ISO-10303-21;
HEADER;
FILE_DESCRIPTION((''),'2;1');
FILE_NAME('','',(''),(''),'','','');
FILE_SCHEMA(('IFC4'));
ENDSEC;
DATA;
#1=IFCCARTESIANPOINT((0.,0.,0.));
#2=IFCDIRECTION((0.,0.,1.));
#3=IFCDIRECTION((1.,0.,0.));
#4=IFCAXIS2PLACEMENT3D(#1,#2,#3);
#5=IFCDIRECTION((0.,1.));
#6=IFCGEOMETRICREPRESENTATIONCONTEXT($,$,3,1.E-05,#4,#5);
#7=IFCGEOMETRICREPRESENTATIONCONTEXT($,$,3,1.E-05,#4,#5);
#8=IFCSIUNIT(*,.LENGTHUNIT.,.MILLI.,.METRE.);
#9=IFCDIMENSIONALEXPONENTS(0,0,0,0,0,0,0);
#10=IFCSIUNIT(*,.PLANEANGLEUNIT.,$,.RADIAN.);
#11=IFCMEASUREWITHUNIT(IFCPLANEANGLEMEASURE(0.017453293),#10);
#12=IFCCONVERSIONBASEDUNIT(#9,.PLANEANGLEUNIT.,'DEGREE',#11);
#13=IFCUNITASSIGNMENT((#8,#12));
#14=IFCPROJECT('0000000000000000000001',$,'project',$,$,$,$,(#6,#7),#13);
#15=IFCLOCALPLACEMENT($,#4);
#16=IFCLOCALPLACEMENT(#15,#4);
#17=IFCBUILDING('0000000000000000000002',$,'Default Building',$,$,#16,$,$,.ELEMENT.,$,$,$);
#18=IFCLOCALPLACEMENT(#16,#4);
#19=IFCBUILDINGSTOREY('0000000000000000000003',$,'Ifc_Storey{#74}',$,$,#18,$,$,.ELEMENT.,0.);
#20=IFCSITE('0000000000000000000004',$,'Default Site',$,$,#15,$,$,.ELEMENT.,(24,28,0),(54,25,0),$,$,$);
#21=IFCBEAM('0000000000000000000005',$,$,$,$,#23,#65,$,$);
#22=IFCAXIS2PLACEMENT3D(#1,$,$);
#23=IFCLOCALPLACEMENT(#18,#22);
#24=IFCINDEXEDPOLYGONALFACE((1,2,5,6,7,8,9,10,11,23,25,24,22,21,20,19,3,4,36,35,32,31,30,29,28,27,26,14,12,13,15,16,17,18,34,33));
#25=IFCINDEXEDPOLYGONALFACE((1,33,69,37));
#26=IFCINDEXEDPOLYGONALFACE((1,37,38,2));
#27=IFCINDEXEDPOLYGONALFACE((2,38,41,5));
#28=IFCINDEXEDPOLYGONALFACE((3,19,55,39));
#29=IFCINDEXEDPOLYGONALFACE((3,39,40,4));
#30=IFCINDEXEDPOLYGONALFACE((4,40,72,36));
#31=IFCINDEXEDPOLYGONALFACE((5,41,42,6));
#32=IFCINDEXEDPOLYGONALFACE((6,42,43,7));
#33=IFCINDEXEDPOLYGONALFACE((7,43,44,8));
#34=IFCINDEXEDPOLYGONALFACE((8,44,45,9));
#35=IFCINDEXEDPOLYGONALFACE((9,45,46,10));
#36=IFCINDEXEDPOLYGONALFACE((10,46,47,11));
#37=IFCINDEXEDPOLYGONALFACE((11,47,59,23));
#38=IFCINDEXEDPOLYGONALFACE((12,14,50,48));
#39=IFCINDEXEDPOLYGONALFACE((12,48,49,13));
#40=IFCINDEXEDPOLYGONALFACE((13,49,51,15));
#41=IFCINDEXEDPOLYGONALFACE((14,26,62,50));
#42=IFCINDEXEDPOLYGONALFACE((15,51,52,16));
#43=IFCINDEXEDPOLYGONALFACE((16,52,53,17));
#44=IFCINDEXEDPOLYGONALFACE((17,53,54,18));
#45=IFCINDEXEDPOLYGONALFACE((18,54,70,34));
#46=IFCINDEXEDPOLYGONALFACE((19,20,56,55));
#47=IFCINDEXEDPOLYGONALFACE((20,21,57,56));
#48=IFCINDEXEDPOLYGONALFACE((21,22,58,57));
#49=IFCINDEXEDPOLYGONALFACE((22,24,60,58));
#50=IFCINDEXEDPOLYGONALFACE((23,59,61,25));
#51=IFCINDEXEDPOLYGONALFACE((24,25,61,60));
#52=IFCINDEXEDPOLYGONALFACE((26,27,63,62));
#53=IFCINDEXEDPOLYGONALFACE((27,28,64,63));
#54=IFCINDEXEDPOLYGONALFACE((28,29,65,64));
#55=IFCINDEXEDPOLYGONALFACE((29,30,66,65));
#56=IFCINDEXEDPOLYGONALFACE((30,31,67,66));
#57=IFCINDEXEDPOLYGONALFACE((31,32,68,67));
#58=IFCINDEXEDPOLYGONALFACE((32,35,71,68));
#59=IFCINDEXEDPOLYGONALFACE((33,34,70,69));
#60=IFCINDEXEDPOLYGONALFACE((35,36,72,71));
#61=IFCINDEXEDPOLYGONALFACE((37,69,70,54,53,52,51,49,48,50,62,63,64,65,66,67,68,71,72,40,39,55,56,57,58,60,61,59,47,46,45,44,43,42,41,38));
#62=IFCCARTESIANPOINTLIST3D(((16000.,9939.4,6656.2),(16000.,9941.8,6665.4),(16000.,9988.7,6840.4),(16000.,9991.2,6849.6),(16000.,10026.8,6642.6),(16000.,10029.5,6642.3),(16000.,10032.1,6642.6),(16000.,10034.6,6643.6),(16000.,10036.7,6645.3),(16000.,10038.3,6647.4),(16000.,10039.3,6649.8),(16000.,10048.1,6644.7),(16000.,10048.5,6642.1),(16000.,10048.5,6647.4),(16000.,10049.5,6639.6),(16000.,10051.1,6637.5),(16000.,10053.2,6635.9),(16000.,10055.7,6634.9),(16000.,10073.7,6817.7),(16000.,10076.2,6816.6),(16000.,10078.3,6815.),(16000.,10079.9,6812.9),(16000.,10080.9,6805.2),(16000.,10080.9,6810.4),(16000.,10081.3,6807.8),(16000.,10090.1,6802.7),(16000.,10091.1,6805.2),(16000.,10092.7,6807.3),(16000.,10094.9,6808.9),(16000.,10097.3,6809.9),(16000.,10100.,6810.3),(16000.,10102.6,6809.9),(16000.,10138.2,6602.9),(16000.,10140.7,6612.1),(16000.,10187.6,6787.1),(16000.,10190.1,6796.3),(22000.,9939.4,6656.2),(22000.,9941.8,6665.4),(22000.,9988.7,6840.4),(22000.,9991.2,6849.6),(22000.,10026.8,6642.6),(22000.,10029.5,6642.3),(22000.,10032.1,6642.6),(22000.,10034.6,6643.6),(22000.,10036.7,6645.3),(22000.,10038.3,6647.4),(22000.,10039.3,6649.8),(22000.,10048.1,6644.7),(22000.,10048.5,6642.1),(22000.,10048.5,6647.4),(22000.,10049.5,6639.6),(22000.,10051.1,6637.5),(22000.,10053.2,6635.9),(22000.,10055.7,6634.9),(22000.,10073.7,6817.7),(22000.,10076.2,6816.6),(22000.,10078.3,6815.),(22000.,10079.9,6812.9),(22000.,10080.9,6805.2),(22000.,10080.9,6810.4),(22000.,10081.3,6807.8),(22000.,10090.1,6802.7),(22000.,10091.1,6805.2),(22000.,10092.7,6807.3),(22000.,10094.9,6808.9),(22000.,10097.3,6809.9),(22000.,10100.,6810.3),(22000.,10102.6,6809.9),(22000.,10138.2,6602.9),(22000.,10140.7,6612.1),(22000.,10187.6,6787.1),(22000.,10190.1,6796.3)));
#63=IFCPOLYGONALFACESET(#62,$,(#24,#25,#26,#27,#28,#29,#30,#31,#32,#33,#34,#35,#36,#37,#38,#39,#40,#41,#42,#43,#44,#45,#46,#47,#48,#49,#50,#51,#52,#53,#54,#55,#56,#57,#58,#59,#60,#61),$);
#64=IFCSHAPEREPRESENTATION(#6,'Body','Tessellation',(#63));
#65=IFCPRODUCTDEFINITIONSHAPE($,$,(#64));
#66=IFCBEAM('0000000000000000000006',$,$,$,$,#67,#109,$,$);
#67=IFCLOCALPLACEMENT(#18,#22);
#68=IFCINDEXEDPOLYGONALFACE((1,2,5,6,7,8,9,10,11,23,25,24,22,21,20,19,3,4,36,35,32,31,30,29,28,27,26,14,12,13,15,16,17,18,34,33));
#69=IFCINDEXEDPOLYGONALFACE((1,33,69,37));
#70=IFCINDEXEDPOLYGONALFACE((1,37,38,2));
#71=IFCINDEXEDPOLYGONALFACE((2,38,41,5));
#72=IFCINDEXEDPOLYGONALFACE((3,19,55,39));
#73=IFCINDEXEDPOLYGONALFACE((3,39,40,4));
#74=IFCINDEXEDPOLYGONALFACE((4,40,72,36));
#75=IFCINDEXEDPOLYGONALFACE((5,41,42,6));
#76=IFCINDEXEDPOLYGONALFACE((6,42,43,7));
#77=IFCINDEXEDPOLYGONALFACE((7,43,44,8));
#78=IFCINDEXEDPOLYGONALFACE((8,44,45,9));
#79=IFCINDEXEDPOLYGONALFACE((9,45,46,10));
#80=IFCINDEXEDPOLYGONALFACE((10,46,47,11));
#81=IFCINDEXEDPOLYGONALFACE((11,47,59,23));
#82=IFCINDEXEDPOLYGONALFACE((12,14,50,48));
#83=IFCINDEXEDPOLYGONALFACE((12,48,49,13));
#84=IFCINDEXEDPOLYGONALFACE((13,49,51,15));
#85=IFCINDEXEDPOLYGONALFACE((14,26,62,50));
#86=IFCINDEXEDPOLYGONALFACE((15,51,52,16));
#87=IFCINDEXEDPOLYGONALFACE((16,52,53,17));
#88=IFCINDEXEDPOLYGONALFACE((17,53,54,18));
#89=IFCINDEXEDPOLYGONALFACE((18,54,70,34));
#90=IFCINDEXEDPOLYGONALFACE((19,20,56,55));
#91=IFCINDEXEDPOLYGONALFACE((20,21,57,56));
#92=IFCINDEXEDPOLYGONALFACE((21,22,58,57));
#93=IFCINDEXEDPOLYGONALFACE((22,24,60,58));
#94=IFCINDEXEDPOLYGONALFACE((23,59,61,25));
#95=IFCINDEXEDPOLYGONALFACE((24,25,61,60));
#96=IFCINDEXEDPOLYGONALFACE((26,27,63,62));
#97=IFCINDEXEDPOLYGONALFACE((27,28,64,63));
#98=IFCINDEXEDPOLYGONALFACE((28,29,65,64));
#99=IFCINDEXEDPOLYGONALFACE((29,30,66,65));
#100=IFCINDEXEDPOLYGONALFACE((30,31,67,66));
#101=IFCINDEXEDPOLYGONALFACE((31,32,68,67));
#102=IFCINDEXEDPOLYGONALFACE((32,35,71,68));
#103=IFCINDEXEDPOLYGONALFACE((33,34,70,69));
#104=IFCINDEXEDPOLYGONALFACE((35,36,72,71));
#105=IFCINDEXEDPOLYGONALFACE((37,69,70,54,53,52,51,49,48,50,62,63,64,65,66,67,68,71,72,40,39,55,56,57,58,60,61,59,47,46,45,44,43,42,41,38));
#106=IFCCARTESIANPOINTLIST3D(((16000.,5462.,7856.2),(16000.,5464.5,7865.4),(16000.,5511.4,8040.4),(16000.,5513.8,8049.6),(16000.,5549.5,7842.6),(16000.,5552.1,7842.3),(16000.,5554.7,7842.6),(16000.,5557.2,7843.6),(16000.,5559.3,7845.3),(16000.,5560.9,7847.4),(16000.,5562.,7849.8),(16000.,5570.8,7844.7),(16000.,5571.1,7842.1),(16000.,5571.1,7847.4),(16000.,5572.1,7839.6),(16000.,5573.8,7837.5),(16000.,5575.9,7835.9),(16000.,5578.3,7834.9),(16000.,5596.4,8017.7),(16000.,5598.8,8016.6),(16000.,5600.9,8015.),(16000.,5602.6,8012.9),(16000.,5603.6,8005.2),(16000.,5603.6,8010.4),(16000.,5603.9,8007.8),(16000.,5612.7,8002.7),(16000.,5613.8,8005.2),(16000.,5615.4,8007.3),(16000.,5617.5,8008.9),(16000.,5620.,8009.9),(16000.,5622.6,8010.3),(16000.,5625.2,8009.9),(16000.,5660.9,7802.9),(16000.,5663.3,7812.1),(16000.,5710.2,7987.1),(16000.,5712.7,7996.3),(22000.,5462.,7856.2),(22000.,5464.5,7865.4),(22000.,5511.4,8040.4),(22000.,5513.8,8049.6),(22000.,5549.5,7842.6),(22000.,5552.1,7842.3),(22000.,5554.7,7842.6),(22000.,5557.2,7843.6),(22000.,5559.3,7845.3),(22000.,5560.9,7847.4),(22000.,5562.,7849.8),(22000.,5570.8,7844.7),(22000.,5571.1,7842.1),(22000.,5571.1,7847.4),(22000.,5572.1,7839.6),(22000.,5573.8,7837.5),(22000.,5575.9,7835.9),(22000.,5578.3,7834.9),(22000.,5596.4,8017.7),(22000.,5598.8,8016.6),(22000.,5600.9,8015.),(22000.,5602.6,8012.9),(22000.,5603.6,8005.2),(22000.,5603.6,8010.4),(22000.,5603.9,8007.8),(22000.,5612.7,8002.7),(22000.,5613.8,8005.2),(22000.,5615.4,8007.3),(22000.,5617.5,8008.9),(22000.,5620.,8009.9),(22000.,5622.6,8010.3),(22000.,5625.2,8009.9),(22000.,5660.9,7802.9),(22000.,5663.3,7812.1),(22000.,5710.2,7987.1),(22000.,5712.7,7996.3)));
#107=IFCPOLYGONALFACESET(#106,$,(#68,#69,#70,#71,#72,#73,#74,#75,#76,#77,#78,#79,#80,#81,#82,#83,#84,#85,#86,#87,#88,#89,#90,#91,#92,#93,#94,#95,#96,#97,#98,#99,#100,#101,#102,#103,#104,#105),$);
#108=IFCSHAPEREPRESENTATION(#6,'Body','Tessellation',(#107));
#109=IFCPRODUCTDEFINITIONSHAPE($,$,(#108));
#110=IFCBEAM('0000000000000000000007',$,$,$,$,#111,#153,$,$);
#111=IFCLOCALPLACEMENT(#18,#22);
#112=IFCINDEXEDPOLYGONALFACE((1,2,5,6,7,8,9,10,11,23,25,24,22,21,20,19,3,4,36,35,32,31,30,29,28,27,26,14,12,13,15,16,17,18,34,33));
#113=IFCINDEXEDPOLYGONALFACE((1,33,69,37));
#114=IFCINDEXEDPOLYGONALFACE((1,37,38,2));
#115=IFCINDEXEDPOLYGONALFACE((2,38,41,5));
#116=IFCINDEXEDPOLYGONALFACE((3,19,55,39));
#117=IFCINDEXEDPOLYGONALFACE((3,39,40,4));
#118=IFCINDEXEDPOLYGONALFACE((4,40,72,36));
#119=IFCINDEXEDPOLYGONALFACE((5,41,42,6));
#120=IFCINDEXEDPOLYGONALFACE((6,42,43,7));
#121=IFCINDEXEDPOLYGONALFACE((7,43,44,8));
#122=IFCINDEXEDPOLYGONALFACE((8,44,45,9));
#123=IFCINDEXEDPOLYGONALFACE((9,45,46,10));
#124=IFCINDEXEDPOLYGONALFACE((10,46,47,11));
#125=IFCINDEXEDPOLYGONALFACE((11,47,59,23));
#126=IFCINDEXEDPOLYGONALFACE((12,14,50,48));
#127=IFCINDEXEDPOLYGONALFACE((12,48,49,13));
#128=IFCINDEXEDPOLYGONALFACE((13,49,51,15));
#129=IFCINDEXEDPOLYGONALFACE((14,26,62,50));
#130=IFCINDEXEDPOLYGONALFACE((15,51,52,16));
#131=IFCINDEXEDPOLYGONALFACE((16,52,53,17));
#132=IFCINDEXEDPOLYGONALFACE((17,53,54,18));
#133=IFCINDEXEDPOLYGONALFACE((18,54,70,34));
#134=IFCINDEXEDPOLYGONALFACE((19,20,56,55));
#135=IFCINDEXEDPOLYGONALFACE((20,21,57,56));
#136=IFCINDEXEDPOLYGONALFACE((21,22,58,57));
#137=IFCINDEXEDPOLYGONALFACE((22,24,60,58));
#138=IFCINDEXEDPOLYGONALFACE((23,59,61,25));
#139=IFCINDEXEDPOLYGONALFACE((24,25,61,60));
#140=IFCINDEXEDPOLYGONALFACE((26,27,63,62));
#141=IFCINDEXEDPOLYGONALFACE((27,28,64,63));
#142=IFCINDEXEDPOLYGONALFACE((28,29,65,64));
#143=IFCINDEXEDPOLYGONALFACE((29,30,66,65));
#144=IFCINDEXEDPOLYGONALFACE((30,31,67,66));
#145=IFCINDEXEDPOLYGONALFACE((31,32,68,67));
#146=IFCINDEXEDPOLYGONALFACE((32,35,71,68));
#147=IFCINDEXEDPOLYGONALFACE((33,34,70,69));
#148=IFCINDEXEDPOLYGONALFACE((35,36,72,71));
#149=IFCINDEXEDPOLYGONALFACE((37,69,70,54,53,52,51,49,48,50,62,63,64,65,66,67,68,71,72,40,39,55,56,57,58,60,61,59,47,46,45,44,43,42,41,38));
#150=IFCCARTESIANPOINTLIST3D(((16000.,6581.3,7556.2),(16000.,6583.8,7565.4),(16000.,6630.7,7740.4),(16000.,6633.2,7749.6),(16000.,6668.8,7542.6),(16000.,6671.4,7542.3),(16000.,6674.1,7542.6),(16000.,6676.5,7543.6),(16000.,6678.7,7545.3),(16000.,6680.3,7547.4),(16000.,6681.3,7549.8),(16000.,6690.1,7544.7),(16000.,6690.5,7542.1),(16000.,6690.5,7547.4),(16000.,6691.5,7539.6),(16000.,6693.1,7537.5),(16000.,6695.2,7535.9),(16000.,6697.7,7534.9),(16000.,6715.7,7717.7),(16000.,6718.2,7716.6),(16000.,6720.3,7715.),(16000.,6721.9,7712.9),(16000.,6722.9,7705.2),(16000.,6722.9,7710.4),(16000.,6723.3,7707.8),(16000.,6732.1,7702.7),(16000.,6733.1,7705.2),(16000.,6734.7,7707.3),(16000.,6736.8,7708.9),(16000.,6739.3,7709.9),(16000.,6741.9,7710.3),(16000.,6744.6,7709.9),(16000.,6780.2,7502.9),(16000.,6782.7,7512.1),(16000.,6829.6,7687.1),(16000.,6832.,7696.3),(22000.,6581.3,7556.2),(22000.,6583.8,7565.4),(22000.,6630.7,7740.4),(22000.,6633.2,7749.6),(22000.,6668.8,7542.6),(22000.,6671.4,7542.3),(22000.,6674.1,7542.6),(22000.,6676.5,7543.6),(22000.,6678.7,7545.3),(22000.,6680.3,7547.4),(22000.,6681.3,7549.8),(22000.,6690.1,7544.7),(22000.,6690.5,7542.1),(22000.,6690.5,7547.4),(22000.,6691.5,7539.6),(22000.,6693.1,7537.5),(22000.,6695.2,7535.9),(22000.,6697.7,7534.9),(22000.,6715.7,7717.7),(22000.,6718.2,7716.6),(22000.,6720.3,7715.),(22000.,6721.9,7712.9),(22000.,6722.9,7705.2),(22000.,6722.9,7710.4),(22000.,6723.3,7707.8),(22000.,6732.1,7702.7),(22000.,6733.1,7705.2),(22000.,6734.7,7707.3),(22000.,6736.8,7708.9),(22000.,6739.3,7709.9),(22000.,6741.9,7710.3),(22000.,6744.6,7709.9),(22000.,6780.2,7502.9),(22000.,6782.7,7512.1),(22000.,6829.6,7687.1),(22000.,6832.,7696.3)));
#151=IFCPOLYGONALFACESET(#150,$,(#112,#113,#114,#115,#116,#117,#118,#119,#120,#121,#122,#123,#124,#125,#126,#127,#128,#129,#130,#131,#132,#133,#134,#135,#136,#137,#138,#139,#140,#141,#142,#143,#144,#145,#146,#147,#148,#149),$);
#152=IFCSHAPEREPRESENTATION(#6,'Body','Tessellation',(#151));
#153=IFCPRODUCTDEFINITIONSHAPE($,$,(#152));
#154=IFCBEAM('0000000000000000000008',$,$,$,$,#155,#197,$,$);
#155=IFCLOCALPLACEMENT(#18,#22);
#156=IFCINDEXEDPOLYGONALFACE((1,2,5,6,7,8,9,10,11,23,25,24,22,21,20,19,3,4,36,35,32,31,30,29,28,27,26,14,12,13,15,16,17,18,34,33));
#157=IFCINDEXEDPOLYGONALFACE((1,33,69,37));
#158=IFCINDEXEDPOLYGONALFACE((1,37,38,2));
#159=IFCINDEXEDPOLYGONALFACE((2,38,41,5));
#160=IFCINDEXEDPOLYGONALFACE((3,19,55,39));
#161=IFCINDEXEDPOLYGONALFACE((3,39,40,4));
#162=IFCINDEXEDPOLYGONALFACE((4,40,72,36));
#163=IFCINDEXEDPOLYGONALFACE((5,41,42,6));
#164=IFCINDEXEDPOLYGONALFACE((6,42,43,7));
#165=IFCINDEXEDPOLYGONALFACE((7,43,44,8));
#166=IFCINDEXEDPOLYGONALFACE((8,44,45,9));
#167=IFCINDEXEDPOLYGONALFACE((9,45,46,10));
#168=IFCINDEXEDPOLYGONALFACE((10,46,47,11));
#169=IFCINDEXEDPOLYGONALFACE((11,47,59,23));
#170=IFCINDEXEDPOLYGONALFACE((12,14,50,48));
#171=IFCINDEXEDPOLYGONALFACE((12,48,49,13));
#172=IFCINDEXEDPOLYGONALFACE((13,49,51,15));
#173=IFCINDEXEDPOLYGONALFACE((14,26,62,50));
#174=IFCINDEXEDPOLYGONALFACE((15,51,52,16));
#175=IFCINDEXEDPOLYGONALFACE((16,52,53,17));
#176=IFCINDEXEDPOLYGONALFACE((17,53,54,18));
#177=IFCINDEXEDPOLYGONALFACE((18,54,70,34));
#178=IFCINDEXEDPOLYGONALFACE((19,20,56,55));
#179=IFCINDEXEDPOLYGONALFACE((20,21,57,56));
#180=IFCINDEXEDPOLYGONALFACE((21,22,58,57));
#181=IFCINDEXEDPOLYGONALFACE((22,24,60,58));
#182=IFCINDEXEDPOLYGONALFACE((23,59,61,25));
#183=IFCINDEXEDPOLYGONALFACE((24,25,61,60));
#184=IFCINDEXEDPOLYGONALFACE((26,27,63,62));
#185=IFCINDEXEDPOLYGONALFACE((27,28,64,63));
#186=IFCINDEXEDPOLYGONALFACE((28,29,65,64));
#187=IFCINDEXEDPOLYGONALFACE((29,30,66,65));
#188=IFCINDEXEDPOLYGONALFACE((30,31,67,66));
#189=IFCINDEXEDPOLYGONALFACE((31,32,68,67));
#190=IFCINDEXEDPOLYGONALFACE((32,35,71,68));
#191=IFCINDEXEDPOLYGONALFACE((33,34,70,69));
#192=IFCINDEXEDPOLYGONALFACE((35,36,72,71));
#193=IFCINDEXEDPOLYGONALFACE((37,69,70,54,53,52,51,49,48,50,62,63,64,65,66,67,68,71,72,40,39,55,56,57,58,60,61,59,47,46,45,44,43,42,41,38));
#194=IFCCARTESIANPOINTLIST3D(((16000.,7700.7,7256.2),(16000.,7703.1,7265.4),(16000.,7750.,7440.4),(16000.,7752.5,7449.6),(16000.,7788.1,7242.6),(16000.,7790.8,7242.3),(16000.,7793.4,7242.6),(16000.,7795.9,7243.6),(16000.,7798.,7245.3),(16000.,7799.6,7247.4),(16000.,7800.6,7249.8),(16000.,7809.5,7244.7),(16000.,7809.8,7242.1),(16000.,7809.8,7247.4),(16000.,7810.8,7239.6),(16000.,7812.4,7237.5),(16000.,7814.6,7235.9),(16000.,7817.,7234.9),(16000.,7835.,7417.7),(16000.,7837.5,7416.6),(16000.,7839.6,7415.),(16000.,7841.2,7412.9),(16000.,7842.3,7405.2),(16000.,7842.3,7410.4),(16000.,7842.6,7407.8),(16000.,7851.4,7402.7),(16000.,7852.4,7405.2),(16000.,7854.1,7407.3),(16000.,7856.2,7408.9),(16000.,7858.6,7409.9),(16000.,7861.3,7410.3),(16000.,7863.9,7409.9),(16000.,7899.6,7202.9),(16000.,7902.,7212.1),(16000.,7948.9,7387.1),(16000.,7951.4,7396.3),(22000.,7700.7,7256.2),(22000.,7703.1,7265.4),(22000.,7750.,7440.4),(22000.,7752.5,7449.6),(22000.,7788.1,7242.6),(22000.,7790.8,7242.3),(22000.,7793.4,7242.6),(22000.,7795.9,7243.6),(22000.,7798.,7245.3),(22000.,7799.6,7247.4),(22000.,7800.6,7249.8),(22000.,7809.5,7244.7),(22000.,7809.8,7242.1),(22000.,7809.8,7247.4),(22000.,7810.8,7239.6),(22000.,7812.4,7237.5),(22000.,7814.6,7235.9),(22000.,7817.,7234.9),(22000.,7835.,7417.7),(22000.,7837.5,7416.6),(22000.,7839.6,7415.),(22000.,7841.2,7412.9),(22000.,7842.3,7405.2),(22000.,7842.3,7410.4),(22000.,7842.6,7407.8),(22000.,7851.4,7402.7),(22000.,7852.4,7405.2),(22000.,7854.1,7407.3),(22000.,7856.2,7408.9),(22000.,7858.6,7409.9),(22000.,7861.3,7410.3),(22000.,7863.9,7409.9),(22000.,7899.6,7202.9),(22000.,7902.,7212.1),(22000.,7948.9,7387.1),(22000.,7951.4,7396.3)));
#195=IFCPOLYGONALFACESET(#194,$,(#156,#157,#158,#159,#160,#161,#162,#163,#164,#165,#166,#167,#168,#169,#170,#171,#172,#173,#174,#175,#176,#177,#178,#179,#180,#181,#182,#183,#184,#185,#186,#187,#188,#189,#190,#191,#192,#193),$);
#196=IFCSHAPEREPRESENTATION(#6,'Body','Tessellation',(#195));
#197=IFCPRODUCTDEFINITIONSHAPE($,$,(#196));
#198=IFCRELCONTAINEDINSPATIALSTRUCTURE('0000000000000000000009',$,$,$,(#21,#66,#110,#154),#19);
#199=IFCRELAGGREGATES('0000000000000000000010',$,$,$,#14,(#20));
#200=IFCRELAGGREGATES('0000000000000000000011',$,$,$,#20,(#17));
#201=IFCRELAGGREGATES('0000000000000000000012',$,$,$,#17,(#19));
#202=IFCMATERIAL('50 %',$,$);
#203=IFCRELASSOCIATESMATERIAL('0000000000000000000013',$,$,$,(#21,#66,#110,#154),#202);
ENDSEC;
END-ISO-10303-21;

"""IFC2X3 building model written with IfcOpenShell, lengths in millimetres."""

from ifc_helpers import new_model, entity, si_unit, converted_unit, direction, frame, origin_with_axes, origin_2d_with_axis, place, context, project, spatial, i_section, extrude, material, element, save


model = new_model("IFC2X3")

# Units and contexts
context_of_model_1 = context(None, 3, precision=1e-05, world=origin_with_axes(), true_north=direction((0.0, 1.0)))
context_of_model_2 = context(None, 3, precision=1e-05, world=origin_with_axes(), true_north=direction((0.0, 1.0)))
ifc_project = project(units=[si_unit("LENGTHUNIT", "METRE", prefix="MILLI"), converted_unit("PLANEANGLEUNIT", "DEGREE", entity("IfcPlaneAngleMeasure", 0.017453293), si_unit("PLANEANGLEUNIT", "RADIAN"), dimensions=[0, 0, 0, 0, 0, 0, 0])], contexts=[context_of_model_1, context_of_model_2])

# Site, building, storey
site_placement = place(None, origin_with_axes())
site = spatial("IfcSite", under=ifc_project, at=site_placement, Name="Default Site", CompositionType="ELEMENT", RefLatitude=(24, 28, 0), RefLongitude=(54, 25, 0))
building_placement = place(site_placement, origin_with_axes())
building = spatial("IfcBuilding", under=site, at=building_placement, Name="Default Building", CompositionType="ELEMENT")
storey_placement = place(building_placement, origin_with_axes())
storey = spatial("IfcBuildingStorey", under=building, at=storey_placement, Name="Ifc_Storey{#74}", CompositionType="ELEMENT", Elevation=0.0)

# Shared definitions
ifc_material_1 = material(Name="50 %")

# Beams
for number, where, z_axis, x_axis in (
    (1, (16000.0, 10064.7, 6726.3), (0.0, 0.258819, 0.965926), (1.0, 0.0, 0.0)),
    (2, (16000.0, 5587.4, 7926.3), (0.0, 0.258819, 0.965926), (1.0, 0.0, 0.0)),
    (3, (16000.0, 6706.7, 7626.3), (0.0, 0.258819, 0.965926), (1.0, 0.0, 0.0)),
    (4, (16000.0, 7826.0, 7326.3), (0.0, 0.258819, 0.965926), (1.0, 0.0, 0.0)),
):
    element("IfcBeam", number, at=place(storey_placement, frame(where, z_axis=z_axis, x_axis=x_axis)), inside=storey, material=ifc_material_1, context=context_of_model_1, shape_type="SweptSolid", body=[
        extrude(i_section(OverallWidth=205.9, OverallDepth=200.2, WebThickness=9.5, FlangeThickness=9.5, FilletRadius=10.2, at=origin_2d_with_axis()), frame((0.0, 0.0, 0.0), z_axis=(1.0, 0.0, 0.0), x_axis=(0.0, 1.0, 0.0)), (0.0, 0.0, 1.0), 6000.0),
    ])

save(model, "model.ifc")
